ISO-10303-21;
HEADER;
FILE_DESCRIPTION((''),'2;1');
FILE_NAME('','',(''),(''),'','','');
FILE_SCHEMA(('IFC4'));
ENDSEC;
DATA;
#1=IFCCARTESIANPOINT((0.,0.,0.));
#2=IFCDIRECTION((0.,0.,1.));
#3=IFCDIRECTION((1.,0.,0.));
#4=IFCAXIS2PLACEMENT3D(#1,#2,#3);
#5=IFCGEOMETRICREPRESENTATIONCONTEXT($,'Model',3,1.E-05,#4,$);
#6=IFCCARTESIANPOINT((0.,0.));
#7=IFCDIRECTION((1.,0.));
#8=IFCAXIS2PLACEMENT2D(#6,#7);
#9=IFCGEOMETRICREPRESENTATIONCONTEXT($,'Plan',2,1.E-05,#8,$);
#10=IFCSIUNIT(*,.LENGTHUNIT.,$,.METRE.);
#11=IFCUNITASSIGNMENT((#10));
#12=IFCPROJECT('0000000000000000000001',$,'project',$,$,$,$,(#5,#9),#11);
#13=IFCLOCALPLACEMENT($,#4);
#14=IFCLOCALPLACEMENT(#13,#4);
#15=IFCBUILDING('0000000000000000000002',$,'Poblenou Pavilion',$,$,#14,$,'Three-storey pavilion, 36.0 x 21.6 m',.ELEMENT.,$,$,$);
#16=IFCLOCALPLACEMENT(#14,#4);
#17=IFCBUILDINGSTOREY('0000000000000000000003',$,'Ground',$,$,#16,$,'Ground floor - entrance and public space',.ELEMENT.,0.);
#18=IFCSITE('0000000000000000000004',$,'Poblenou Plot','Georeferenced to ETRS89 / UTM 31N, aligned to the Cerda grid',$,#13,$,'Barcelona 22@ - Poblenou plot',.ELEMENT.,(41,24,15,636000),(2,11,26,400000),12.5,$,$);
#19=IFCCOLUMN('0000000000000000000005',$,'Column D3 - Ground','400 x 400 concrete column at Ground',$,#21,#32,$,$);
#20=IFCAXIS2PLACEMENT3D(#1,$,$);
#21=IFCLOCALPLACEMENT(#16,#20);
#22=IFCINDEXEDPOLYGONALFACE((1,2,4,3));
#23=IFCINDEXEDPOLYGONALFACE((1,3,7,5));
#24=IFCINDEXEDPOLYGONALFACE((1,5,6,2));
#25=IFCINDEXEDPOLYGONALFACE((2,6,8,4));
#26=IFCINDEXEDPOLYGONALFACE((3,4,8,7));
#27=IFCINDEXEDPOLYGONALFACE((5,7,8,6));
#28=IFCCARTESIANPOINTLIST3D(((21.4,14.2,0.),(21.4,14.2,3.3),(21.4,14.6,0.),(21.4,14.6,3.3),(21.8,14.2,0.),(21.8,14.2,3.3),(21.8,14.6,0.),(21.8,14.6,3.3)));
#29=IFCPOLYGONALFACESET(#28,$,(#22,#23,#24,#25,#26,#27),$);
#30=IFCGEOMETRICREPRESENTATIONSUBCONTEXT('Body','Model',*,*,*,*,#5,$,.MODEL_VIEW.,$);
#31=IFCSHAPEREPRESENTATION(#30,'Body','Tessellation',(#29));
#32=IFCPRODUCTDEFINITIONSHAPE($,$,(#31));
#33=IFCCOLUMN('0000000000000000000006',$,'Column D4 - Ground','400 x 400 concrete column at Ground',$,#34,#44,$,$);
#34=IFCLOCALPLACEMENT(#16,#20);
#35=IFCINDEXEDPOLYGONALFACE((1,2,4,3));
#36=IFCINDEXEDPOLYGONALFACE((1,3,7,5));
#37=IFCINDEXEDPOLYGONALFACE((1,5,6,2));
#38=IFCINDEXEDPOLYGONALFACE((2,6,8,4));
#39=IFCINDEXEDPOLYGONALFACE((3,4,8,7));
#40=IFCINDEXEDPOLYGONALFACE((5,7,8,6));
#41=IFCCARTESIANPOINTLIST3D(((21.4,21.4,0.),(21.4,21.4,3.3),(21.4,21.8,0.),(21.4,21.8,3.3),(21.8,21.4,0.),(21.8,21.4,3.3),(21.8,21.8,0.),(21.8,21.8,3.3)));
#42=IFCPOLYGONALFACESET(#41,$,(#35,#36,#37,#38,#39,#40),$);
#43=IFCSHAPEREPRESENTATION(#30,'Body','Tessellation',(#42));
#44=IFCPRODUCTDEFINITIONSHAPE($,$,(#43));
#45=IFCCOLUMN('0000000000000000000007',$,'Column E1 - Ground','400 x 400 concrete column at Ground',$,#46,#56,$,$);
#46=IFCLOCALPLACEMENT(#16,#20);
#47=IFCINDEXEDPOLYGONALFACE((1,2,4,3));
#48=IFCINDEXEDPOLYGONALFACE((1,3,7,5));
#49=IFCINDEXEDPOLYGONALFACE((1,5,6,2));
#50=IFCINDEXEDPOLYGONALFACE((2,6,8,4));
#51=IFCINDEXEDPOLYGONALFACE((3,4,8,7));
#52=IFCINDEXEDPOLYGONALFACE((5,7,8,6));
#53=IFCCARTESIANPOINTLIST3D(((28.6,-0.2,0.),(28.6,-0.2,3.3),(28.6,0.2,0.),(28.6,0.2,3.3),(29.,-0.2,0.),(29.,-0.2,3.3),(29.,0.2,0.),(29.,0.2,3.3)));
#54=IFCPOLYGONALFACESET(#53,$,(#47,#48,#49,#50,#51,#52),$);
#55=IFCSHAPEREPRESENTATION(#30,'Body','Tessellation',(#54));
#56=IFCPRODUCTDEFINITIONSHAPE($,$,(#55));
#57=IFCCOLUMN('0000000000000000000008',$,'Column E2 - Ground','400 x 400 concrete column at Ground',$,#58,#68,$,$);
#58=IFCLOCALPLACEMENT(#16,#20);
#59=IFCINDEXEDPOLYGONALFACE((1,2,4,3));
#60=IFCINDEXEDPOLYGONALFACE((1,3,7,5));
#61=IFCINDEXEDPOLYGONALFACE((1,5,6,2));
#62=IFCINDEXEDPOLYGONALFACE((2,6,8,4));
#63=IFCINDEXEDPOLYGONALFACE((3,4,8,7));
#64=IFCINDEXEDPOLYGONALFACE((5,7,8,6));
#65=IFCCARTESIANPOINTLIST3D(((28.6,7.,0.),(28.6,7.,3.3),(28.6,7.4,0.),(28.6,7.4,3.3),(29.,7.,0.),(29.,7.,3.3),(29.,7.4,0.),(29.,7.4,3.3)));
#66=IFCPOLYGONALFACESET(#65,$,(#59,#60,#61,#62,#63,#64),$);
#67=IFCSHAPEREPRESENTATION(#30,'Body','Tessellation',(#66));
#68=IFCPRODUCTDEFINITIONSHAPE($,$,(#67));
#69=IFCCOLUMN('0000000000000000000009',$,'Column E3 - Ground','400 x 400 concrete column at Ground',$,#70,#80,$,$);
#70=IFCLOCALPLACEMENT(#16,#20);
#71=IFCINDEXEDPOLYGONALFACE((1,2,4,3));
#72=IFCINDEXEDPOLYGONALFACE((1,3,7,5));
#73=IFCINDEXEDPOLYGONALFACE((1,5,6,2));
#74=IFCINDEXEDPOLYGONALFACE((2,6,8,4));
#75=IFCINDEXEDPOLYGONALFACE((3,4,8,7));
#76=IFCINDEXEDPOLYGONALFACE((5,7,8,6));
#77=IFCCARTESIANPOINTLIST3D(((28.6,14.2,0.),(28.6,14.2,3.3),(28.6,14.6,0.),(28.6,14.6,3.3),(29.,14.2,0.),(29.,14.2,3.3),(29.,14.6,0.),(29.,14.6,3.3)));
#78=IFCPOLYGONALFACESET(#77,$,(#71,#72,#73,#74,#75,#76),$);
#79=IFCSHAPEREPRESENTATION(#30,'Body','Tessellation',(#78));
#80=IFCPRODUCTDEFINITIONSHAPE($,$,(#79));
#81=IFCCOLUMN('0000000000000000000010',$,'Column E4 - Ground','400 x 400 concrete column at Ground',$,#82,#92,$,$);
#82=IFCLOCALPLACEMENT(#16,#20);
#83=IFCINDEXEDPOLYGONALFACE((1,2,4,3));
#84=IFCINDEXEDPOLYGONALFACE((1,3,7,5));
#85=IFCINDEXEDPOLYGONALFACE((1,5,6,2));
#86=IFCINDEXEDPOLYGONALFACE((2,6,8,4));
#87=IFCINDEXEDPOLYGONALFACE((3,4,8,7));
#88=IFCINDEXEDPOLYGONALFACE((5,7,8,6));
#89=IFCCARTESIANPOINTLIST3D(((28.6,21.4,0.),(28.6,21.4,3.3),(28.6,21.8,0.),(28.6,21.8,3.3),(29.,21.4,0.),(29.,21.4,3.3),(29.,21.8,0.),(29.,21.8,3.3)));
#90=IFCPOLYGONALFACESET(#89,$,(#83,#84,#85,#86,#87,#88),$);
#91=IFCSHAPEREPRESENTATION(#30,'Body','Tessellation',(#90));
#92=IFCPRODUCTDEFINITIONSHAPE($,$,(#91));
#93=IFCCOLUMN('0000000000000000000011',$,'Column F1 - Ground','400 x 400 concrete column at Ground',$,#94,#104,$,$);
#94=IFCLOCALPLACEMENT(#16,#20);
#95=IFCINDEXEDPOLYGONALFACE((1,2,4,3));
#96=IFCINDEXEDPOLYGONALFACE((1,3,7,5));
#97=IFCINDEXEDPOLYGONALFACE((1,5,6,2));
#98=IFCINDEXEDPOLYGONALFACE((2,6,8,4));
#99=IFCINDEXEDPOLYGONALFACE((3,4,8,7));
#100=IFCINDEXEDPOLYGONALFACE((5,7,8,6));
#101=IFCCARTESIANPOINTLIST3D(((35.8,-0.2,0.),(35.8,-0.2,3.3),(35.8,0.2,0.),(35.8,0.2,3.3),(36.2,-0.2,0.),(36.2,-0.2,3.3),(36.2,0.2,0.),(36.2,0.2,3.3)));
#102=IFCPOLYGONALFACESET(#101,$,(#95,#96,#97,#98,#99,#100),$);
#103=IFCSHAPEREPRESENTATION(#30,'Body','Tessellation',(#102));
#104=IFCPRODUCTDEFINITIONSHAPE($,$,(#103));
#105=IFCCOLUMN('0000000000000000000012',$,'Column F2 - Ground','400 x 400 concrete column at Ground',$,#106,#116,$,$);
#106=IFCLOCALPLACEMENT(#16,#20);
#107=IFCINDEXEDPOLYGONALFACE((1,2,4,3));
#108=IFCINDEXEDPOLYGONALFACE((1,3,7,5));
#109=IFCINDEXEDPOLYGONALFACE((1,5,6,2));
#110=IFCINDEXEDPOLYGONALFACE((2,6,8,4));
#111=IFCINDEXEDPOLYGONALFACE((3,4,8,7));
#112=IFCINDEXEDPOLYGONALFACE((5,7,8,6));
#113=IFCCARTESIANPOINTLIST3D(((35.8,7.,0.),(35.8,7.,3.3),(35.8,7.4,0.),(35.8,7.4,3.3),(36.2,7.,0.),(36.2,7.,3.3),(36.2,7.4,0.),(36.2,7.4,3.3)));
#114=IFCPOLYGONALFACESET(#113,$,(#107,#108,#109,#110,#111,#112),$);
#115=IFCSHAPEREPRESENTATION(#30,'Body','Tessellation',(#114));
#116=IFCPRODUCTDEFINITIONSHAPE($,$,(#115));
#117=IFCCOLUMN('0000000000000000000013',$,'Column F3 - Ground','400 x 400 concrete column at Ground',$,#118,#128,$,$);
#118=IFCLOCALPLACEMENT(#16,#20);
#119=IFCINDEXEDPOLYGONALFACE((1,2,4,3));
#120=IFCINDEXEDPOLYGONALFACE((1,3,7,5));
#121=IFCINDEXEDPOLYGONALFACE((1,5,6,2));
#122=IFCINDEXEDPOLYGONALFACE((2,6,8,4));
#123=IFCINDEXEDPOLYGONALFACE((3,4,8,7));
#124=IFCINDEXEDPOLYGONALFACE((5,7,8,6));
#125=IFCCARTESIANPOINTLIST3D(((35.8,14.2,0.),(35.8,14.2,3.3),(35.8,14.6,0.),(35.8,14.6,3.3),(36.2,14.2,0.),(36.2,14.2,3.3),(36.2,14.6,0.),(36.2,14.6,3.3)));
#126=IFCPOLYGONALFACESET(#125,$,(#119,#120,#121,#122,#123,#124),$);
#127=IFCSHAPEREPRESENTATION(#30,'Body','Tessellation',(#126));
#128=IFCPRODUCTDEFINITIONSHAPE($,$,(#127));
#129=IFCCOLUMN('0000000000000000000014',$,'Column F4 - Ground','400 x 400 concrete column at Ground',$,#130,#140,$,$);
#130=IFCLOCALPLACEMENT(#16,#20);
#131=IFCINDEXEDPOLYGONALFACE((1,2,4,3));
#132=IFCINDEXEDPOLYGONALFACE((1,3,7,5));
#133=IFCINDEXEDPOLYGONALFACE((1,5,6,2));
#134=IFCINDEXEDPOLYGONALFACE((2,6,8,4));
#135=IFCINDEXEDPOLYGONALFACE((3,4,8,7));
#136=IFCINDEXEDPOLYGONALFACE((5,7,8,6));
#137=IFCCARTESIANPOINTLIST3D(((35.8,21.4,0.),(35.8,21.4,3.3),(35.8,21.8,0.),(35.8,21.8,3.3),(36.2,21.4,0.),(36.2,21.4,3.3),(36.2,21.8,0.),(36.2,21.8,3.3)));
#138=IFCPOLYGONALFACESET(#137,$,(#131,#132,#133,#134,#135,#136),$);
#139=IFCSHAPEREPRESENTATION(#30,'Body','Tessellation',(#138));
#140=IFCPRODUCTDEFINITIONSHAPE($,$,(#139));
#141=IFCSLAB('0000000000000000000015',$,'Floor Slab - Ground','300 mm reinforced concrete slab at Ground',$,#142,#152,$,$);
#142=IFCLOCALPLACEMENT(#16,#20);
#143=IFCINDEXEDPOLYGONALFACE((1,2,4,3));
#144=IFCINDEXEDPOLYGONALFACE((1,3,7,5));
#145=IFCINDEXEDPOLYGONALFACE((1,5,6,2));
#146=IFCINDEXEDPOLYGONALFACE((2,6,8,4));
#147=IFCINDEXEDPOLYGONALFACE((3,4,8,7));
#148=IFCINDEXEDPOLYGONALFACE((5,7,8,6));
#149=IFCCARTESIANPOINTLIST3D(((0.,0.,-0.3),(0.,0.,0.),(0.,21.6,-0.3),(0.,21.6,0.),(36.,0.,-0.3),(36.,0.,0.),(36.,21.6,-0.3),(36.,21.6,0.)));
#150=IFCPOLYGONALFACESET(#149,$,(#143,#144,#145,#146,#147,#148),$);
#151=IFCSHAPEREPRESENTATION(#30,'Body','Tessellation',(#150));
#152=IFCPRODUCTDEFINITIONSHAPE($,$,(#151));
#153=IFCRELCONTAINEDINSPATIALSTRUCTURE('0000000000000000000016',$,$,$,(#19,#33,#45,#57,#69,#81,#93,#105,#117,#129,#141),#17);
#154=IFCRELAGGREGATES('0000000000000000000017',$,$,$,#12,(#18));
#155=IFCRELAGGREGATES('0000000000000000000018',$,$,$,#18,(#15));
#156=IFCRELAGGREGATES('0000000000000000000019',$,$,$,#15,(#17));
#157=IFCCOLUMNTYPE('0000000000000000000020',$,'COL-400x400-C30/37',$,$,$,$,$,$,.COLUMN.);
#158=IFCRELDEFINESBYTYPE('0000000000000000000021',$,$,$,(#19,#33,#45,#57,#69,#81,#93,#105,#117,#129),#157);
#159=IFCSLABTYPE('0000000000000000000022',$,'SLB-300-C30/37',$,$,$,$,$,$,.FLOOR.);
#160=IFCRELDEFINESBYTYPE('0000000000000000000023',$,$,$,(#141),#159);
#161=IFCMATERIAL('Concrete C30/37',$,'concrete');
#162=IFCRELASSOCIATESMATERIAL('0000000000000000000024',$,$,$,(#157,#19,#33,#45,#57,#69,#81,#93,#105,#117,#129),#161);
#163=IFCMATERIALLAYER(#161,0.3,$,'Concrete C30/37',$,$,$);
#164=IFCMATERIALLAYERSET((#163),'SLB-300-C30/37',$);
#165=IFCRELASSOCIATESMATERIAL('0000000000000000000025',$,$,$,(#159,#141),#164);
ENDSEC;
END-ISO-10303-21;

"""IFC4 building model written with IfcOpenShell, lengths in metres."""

from ifc_helpers import new_model, si_unit, frame, origin_with_axes, origin_2d_with_axis, place, context, subcontext, project, spatial, line, indexed_curve, rectangle, outline, extrude, material, layer, layer_set, layer_usage, material_profile, profile_set, profile_usage, type_object, element, save


model = new_model("IFC4")

# Units and contexts
model_context = context("Model", 3, precision=1e-05, world=origin_with_axes())
plan_context = context("Plan", 2, precision=1e-05, world=origin_2d_with_axis())
body_context = subcontext(model_context, "Body", "Model", "MODEL_VIEW")
ifc_project = project(units=[si_unit("LENGTHUNIT", "METRE")], contexts=[model_context, plan_context])

# Site, building, storey
site_placement = place(None, origin_with_axes())
site = spatial("IfcSite", under=ifc_project, at=site_placement, Name="Poblenou Plot", Description="Georeferenced to ETRS89 / UTM 31N, aligned to the Cerda grid", LongName="Barcelona 22@ - Poblenou plot", CompositionType="ELEMENT", RefLatitude=(41, 24, 15, 636000), RefLongitude=(2, 11, 26, 400000), RefElevation=12.5)
building_placement = place(site_placement, origin_with_axes())
building = spatial("IfcBuilding", under=site, at=building_placement, Name="Poblenou Pavilion", LongName="Three-storey pavilion, 36.0 x 21.6 m", CompositionType="ELEMENT")
storey_placement = place(building_placement, origin_with_axes())
storey = spatial("IfcBuildingStorey", under=building, at=storey_placement, Name="Ground", LongName="Ground floor - entrance and public space", CompositionType="ELEMENT", Elevation=0.0)

# Columns
ifc_material = material(Name="Concrete C30/37", Category="concrete")
ifc_material_profile = material_profile(ifc_material, rectangle(XDim=0.4, YDim=0.4))
ifc_profile_set = profile_set([ifc_material_profile], Name="COL-400x400-C30/37")
column_type = type_object("IfcColumnType", Name="COL-400x400-C30/37", PredefinedType="COLUMN", material=ifc_profile_set)
ifc_profile_usage_1 = profile_usage(ifc_profile_set)
column_1_placement = place(storey_placement, frame((21.4, 14.2, 0.0), z_axis=(0.0, 0.0, 1.0), x_axis=(1.0, 0.0, 0.0)))
element("IfcColumn", 1, at=column_1_placement, inside=storey, type_object=column_type, material=ifc_profile_usage_1, Name="Column D3 - Ground", Description="400 x 400 concrete column at Ground", context=body_context, shape_type="SweptSolid", body=[
    extrude(outline(indexed_curve([(0.0, 0.0), (0.4, 0.0), (0.4, 0.4), (0.0, 0.4)], segments=[line(1, 2, 3, 4, 1)])), origin_with_axes(), (0.0, 0.0, 1.0), 3.3),
])
ifc_profile_usage_2 = profile_usage(ifc_profile_set)
column_2_placement = place(storey_placement, frame((21.4, 21.4, 0.0), z_axis=(0.0, 0.0, 1.0), x_axis=(1.0, 0.0, 0.0)))
element("IfcColumn", 2, at=column_2_placement, inside=storey, type_object=column_type, material=ifc_profile_usage_2, Name="Column D4 - Ground", Description="400 x 400 concrete column at Ground", context=body_context, shape_type="SweptSolid", body=[
    extrude(outline(indexed_curve([(0.0, 0.0), (0.4, 0.0), (0.4, 0.4), (0.0, 0.4)], segments=[line(1, 2, 3, 4, 1)])), origin_with_axes(), (0.0, 0.0, 1.0), 3.3),
])
ifc_profile_usage_3 = profile_usage(ifc_profile_set)
column_3_placement = place(storey_placement, frame((28.6, -0.2, 0.0), z_axis=(0.0, 0.0, 1.0), x_axis=(1.0, 0.0, 0.0)))
element("IfcColumn", 3, at=column_3_placement, inside=storey, type_object=column_type, material=ifc_profile_usage_3, Name="Column E1 - Ground", Description="400 x 400 concrete column at Ground", context=body_context, shape_type="SweptSolid", body=[
    extrude(outline(indexed_curve([(0.0, 0.0), (0.4, 0.0), (0.4, 0.4), (0.0, 0.4)], segments=[line(1, 2, 3, 4, 1)])), origin_with_axes(), (0.0, 0.0, 1.0), 3.3),
])
ifc_profile_usage_4 = profile_usage(ifc_profile_set)
column_4_placement = place(storey_placement, frame((28.6, 7.0, 0.0), z_axis=(0.0, 0.0, 1.0), x_axis=(1.0, 0.0, 0.0)))
element("IfcColumn", 4, at=column_4_placement, inside=storey, type_object=column_type, material=ifc_profile_usage_4, Name="Column E2 - Ground", Description="400 x 400 concrete column at Ground", context=body_context, shape_type="SweptSolid", body=[
    extrude(outline(indexed_curve([(0.0, 0.0), (0.4, 0.0), (0.4, 0.4), (0.0, 0.4)], segments=[line(1, 2, 3, 4, 1)])), origin_with_axes(), (0.0, 0.0, 1.0), 3.3),
])
ifc_profile_usage_5 = profile_usage(ifc_profile_set)
column_5_placement = place(storey_placement, frame((28.6, 14.2, 0.0), z_axis=(0.0, 0.0, 1.0), x_axis=(1.0, 0.0, 0.0)))
element("IfcColumn", 5, at=column_5_placement, inside=storey, type_object=column_type, material=ifc_profile_usage_5, Name="Column E3 - Ground", Description="400 x 400 concrete column at Ground", context=body_context, shape_type="SweptSolid", body=[
    extrude(outline(indexed_curve([(0.0, 0.0), (0.4, 0.0), (0.4, 0.4), (0.0, 0.4)], segments=[line(1, 2, 3, 4, 1)])), origin_with_axes(), (0.0, 0.0, 1.0), 3.3),
])
ifc_profile_usage_6 = profile_usage(ifc_profile_set)
column_6_placement = place(storey_placement, frame((28.6, 21.4, 0.0), z_axis=(0.0, 0.0, 1.0), x_axis=(1.0, 0.0, 0.0)))
element("IfcColumn", 6, at=column_6_placement, inside=storey, type_object=column_type, material=ifc_profile_usage_6, Name="Column E4 - Ground", Description="400 x 400 concrete column at Ground", context=body_context, shape_type="SweptSolid", body=[
    extrude(outline(indexed_curve([(0.0, 0.0), (0.4, 0.0), (0.4, 0.4), (0.0, 0.4)], segments=[line(1, 2, 3, 4, 1)])), origin_with_axes(), (0.0, 0.0, 1.0), 3.3),
])
ifc_profile_usage_7 = profile_usage(ifc_profile_set)
column_7_placement = place(storey_placement, frame((35.8, -0.2, 0.0), z_axis=(0.0, 0.0, 1.0), x_axis=(1.0, 0.0, 0.0)))
element("IfcColumn", 7, at=column_7_placement, inside=storey, type_object=column_type, material=ifc_profile_usage_7, Name="Column F1 - Ground", Description="400 x 400 concrete column at Ground", context=body_context, shape_type="SweptSolid", body=[
    extrude(outline(indexed_curve([(0.0, 0.0), (0.4, 0.0), (0.4, 0.4), (0.0, 0.4)], segments=[line(1, 2, 3, 4, 1)])), origin_with_axes(), (0.0, 0.0, 1.0), 3.3),
])
ifc_profile_usage_8 = profile_usage(ifc_profile_set)
column_8_placement = place(storey_placement, frame((35.8, 7.0, 0.0), z_axis=(0.0, 0.0, 1.0), x_axis=(1.0, 0.0, 0.0)))
element("IfcColumn", 8, at=column_8_placement, inside=storey, type_object=column_type, material=ifc_profile_usage_8, Name="Column F2 - Ground", Description="400 x 400 concrete column at Ground", context=body_context, shape_type="SweptSolid", body=[
    extrude(outline(indexed_curve([(0.0, 0.0), (0.4, 0.0), (0.4, 0.4), (0.0, 0.4)], segments=[line(1, 2, 3, 4, 1)])), origin_with_axes(), (0.0, 0.0, 1.0), 3.3),
])
ifc_profile_usage_9 = profile_usage(ifc_profile_set)
column_9_placement = place(storey_placement, frame((35.8, 14.2, 0.0), z_axis=(0.0, 0.0, 1.0), x_axis=(1.0, 0.0, 0.0)))
element("IfcColumn", 9, at=column_9_placement, inside=storey, type_object=column_type, material=ifc_profile_usage_9, Name="Column F3 - Ground", Description="400 x 400 concrete column at Ground", context=body_context, shape_type="SweptSolid", body=[
    extrude(outline(indexed_curve([(0.0, 0.0), (0.4, 0.0), (0.4, 0.4), (0.0, 0.4)], segments=[line(1, 2, 3, 4, 1)])), origin_with_axes(), (0.0, 0.0, 1.0), 3.3),
])
ifc_profile_usage_10 = profile_usage(ifc_profile_set)
column_10_placement = place(storey_placement, frame((35.8, 21.4, 0.0), z_axis=(0.0, 0.0, 1.0), x_axis=(1.0, 0.0, 0.0)))
element("IfcColumn", 10, at=column_10_placement, inside=storey, type_object=column_type, material=ifc_profile_usage_10, Name="Column F4 - Ground", Description="400 x 400 concrete column at Ground", context=body_context, shape_type="SweptSolid", body=[
    extrude(outline(indexed_curve([(0.0, 0.0), (0.4, 0.0), (0.4, 0.4), (0.0, 0.4)], segments=[line(1, 2, 3, 4, 1)])), origin_with_axes(), (0.0, 0.0, 1.0), 3.3),
])

# Slab
ifc_layer = layer(ifc_material, 0.3, Name="Concrete C30/37")
ifc_layer_set = layer_set([ifc_layer], Name="SLB-300-C30/37")
ifc_layer_usage = layer_usage(ifc_layer_set, "AXIS3", "POSITIVE", 0.0)
slab_type = type_object("IfcSlabType", Name="SLB-300-C30/37", PredefinedType="FLOOR", material=ifc_layer_set)
slab_placement = place(storey_placement, frame((0.0, 0.0, -0.3), z_axis=(0.0, 0.0, 1.0), x_axis=(1.0, 0.0, 0.0)))
element("IfcSlab", 11, at=slab_placement, inside=storey, type_object=slab_type, material=ifc_layer_usage, Name="Floor Slab - Ground", Description="300 mm reinforced concrete slab at Ground", context=body_context, shape_type="SweptSolid", body=[
    extrude(outline(indexed_curve([(0.0, 0.0), (36.0, 0.0), (36.0, 21.6), (0.0, 21.6)], segments=[line(1, 2, 3, 4, 1)])), origin_with_axes(), (0.0, 0.0, 1.0), 0.3),
])

save(model, "model.ifc")
